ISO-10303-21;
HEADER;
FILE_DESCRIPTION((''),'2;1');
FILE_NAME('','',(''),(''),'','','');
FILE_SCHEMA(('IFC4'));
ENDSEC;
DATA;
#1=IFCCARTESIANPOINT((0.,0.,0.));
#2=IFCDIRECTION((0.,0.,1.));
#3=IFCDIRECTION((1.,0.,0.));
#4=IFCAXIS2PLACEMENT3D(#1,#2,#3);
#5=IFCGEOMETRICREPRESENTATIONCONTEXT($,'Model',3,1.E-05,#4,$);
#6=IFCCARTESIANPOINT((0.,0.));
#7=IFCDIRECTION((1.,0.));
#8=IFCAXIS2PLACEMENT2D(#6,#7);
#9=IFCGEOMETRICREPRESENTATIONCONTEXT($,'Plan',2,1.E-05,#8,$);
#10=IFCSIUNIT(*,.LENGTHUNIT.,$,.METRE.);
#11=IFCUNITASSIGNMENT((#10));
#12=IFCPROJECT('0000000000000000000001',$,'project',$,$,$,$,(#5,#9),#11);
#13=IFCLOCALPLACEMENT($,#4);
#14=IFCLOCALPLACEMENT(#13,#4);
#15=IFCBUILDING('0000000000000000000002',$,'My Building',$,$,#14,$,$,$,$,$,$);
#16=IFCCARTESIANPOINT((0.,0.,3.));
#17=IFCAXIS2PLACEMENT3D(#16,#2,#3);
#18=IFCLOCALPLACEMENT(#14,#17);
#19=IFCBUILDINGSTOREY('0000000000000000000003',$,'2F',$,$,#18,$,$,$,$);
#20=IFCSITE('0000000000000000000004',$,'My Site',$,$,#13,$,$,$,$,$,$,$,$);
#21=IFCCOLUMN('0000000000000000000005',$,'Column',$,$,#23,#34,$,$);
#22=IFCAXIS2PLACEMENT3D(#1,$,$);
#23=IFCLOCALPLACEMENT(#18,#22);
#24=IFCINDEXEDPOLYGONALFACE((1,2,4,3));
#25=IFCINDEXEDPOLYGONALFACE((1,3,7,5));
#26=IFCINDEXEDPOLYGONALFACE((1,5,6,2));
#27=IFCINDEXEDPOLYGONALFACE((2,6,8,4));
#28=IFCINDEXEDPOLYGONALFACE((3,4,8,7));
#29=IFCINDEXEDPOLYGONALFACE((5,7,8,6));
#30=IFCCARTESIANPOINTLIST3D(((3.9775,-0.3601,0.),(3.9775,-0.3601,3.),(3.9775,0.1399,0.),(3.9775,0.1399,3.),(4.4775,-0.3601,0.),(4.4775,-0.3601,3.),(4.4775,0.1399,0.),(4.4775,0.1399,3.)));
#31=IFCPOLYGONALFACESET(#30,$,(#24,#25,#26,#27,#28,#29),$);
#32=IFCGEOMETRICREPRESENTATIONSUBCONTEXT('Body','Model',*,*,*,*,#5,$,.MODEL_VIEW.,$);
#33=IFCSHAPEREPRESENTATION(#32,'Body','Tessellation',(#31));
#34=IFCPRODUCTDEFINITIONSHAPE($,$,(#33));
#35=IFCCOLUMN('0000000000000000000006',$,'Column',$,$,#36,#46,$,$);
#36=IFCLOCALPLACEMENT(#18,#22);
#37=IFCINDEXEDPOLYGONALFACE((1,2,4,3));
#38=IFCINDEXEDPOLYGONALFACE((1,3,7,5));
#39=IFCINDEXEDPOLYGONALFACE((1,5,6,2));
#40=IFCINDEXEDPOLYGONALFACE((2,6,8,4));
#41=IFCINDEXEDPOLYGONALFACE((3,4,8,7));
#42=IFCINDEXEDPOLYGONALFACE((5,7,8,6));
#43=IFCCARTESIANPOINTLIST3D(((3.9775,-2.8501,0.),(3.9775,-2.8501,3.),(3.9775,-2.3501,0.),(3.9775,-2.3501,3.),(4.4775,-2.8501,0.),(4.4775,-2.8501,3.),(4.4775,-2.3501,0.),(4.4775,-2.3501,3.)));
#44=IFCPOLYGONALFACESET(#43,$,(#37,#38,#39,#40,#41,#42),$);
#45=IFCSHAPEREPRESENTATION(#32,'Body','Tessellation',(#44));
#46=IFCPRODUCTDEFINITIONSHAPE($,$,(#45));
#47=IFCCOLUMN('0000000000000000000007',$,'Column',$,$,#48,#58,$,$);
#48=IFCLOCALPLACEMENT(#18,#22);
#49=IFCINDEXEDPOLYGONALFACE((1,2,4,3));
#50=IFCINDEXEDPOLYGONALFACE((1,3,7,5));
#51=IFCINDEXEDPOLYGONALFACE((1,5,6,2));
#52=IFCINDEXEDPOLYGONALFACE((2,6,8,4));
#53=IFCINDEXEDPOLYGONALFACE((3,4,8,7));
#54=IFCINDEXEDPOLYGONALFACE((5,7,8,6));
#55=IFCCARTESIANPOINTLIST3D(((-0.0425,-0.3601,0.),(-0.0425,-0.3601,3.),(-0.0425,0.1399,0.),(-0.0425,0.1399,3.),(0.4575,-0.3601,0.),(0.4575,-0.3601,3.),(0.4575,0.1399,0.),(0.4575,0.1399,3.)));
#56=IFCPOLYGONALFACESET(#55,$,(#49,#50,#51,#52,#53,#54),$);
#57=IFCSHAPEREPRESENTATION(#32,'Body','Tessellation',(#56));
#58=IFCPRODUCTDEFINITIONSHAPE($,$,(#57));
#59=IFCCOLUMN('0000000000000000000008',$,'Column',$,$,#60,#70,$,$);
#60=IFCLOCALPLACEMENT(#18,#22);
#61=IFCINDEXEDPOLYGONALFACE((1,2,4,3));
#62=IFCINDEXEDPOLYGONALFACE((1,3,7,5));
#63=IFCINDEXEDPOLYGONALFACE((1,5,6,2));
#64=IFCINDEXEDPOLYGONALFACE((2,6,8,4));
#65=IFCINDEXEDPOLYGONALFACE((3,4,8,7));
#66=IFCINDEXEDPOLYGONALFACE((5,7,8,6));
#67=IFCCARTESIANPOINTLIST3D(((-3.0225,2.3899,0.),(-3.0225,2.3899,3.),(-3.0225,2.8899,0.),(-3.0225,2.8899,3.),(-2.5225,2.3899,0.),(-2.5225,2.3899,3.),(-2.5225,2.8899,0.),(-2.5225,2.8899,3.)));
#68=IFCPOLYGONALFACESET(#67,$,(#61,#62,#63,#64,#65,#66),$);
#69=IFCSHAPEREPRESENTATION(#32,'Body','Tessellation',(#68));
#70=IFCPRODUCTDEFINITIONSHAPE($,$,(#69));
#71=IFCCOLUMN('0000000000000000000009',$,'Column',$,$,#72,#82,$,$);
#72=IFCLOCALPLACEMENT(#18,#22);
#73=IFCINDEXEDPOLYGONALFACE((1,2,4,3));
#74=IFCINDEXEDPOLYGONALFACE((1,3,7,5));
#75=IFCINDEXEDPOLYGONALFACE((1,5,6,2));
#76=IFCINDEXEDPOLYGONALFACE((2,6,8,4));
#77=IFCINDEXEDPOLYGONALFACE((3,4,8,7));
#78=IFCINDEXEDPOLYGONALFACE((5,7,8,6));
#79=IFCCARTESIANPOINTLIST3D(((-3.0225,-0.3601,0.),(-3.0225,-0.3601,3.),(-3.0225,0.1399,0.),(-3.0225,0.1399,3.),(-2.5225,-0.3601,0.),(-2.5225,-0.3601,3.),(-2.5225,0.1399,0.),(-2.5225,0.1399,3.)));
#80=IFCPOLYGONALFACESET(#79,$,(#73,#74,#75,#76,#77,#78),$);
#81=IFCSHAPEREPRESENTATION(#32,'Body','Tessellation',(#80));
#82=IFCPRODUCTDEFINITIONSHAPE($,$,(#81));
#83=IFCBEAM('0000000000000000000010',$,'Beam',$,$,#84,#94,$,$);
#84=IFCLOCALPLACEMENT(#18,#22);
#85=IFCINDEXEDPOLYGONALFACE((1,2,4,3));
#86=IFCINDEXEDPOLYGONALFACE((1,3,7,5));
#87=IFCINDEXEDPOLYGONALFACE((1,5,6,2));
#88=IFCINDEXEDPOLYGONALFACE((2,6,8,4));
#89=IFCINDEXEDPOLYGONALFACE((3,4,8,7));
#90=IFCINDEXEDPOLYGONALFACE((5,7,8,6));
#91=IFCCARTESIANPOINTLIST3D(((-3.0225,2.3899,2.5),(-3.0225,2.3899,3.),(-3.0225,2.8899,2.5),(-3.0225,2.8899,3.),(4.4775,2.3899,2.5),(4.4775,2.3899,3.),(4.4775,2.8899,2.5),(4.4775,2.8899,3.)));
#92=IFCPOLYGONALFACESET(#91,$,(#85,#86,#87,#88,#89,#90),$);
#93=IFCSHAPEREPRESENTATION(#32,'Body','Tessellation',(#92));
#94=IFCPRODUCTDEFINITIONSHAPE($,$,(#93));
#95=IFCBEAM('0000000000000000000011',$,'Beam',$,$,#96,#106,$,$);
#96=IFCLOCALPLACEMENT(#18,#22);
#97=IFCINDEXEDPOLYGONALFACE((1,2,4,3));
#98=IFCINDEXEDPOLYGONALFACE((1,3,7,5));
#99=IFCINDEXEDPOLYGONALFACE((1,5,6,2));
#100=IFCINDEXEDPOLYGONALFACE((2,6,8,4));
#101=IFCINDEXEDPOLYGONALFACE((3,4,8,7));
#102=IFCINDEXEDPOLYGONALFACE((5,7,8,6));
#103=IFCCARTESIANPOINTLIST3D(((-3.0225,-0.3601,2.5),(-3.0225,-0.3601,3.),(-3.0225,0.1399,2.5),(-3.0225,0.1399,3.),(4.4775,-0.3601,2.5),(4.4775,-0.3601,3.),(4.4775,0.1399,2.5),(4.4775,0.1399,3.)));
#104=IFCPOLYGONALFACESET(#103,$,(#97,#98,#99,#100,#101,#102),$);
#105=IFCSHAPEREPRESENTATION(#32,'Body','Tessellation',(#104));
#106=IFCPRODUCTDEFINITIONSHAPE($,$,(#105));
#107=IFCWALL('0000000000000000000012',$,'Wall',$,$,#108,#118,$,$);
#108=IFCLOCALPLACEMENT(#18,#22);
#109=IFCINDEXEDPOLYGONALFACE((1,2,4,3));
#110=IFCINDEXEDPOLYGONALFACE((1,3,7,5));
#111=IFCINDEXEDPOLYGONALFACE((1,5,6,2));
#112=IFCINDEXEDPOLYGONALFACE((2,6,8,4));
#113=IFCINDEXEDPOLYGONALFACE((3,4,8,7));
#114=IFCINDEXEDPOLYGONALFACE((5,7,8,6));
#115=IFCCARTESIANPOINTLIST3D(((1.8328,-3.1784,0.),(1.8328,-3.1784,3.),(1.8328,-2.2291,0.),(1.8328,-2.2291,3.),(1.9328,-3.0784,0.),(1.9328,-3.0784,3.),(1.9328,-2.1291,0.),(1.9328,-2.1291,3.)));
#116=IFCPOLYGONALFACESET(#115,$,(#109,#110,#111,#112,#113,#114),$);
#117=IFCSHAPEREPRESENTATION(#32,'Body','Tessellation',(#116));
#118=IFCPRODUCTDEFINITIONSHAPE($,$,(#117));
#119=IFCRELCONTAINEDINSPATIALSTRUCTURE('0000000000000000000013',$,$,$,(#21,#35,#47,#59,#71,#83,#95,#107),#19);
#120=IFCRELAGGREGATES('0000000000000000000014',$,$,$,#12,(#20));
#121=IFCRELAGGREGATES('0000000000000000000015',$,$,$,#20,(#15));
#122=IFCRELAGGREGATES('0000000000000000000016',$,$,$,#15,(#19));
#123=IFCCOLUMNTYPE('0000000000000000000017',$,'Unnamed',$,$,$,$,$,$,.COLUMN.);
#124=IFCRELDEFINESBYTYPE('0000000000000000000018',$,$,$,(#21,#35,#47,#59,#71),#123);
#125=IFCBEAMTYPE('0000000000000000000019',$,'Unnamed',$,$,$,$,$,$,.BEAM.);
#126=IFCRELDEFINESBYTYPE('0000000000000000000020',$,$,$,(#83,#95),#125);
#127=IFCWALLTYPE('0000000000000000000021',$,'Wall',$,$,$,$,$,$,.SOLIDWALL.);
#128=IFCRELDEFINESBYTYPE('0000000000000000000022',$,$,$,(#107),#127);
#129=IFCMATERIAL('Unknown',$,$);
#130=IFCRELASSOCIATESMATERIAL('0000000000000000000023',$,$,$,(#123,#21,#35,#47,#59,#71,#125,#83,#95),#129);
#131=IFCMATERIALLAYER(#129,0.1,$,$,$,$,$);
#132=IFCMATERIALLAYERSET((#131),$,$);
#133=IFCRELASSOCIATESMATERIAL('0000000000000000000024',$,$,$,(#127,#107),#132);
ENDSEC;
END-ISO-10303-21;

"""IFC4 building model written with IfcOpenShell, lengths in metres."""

from ifc_helpers import new_model, si_unit, frame, origin_with_axes, origin_2d_with_axis, place, context, subcontext, project, spatial, line, indexed_curve, rectangle, outline, extrude, material, layer, layer_set, layer_usage, material_profile, profile_set, profile_usage, type_object, element, save


model = new_model("IFC4")

# Units and contexts
model_context = context("Model", 3, precision=1e-05, world=origin_with_axes())
plan_context = context("Plan", 2, precision=1e-05, world=origin_2d_with_axis())
body_context_1 = subcontext(model_context, "Body", "Model", "MODEL_VIEW")
ifc_project = project(units=[si_unit("LENGTHUNIT", "METRE")], contexts=[model_context, plan_context])

# Site, building, storey
site_placement = place(None, origin_with_axes())
site = spatial("IfcSite", under=ifc_project, at=site_placement, Name="My Site")
building_placement = place(site_placement, origin_with_axes())
building = spatial("IfcBuilding", under=site, at=building_placement, Name="My Building")
storey_placement = place(building_placement, frame((0.0, 0.0, 3.0), z_axis=(0.0, 0.0, 1.0), x_axis=(1.0, 0.0, 0.0)))
storey = spatial("IfcBuildingStorey", under=building, at=storey_placement, Name="2F")

# Columns
ifc_material = material(Name="Unknown")
ifc_material_profile_1 = material_profile(ifc_material, rectangle(XDim=0.5, YDim=0.5))
ifc_profile_set_1 = profile_set([ifc_material_profile_1])
ifc_profile_usage_1 = profile_usage(ifc_profile_set_1, cardinal=5)
column_type = type_object("IfcColumnType", Name="Unnamed", PredefinedType="COLUMN", material=ifc_profile_set_1)
column_1_placement = place(storey_placement, frame((4.2275, -0.1101, 0.0), z_axis=(0.0, 0.0, 1.0), x_axis=(1.0, 0.0, 0.0)))
element("IfcColumn", 1, at=column_1_placement, inside=storey, type_object=column_type, material=ifc_profile_usage_1, Name="Column", context=body_context_1, shape_type="SweptSolid", body=[
    extrude(rectangle(XDim=0.5, YDim=0.5), origin_with_axes(), (0.0, 0.0, 1.0), 3.0),
])
ifc_profile_usage_2 = profile_usage(ifc_profile_set_1, cardinal=5)
column_2_placement = place(storey_placement, frame((4.2275, -2.6001, 0.0), z_axis=(0.0, 0.0, 1.0), x_axis=(1.0, 0.0, 0.0)))
element("IfcColumn", 2, at=column_2_placement, inside=storey, type_object=column_type, material=ifc_profile_usage_2, Name="Column", context=body_context_1, shape_type="SweptSolid", body=[
    extrude(rectangle(XDim=0.5, YDim=0.5), origin_with_axes(), (0.0, 0.0, 1.0), 3.0),
])
ifc_profile_usage_3 = profile_usage(ifc_profile_set_1, cardinal=5)
column_3_placement = place(storey_placement, frame((0.2075, -0.1101, 0.0), z_axis=(0.0, 0.0, 1.0), x_axis=(1.0, 0.0, 0.0)))
element("IfcColumn", 3, at=column_3_placement, inside=storey, type_object=column_type, material=ifc_profile_usage_3, Name="Column", context=body_context_1, shape_type="SweptSolid", body=[
    extrude(rectangle(XDim=0.5, YDim=0.5), origin_with_axes(), (0.0, 0.0, 1.0), 3.0),
])
ifc_profile_usage_4 = profile_usage(ifc_profile_set_1, cardinal=5)
column_4_placement = place(storey_placement, frame((-2.7725, 2.6399, 0.0), z_axis=(0.0, 0.0, 1.0), x_axis=(1.0, 0.0, 0.0)))
element("IfcColumn", 4, at=column_4_placement, inside=storey, type_object=column_type, material=ifc_profile_usage_4, Name="Column", context=body_context_1, shape_type="SweptSolid", body=[
    extrude(rectangle(XDim=0.5, YDim=0.5), origin_with_axes(), (0.0, 0.0, 1.0), 3.0),
])
ifc_profile_usage_5 = profile_usage(ifc_profile_set_1, cardinal=5)
column_5_placement = place(storey_placement, frame((-2.7725, -0.1101, 0.0), z_axis=(0.0, 0.0, 1.0), x_axis=(1.0, 0.0, 0.0)))
element("IfcColumn", 5, at=column_5_placement, inside=storey, type_object=column_type, material=ifc_profile_usage_5, Name="Column", context=body_context_1, shape_type="SweptSolid", body=[
    extrude(rectangle(XDim=0.5, YDim=0.5), origin_with_axes(), (0.0, 0.0, 1.0), 3.0),
])

# Beams
ifc_material_profile_2 = material_profile(ifc_material, rectangle(XDim=0.5, YDim=0.5))
ifc_profile_set_2 = profile_set([ifc_material_profile_2])
ifc_profile_usage_6 = profile_usage(ifc_profile_set_2, cardinal=7)
beam_type = type_object("IfcBeamType", Name="Unnamed", PredefinedType="BEAM", material=ifc_profile_set_2)
beam_1_placement = place(storey_placement, frame((4.4775, 2.3899, 3.0), z_axis=(-1.0, 0.0, 0.0), x_axis=(0.0, -1.0, 0.0)))
element("IfcBeam", 6, at=beam_1_placement, inside=storey, type_object=beam_type, material=ifc_profile_usage_6, Name="Beam", context=body_context_1, shape_type="SweptSolid", body=[
    extrude(rectangle(XDim=0.5, YDim=0.5), frame((-0.25, -0.25, 0.0), z_axis=(0.0, 0.0, 1.0), x_axis=(1.0, 0.0, 0.0)), (0.0, 0.0, 1.0), 7.5),
])
ifc_profile_usage_7 = profile_usage(ifc_profile_set_2, cardinal=7)
beam_2_placement = place(storey_placement, frame((4.4775, -0.3601, 3.0), z_axis=(-1.0, 0.0, 0.0), x_axis=(0.0, -1.0, 0.0)))
element("IfcBeam", 7, at=beam_2_placement, inside=storey, type_object=beam_type, material=ifc_profile_usage_7, Name="Beam", context=body_context_1, shape_type="SweptSolid", body=[
    extrude(rectangle(XDim=0.5, YDim=0.5), frame((-0.25, -0.25, 0.0), z_axis=(0.0, 0.0, 1.0), x_axis=(1.0, 0.0, 0.0)), (0.0, 0.0, 1.0), 7.5),
])

# Wall
ifc_layer = layer(ifc_material, 0.1)
ifc_layer_set = layer_set([ifc_layer])
ifc_layer_usage_1 = layer_usage(ifc_layer_set, "AXIS2", "POSITIVE", 0.0)
wall_type = type_object("IfcWallType", Name="Wall", PredefinedType="SOLIDWALL", material=ifc_layer_set)
wall_1_placement = place(storey_placement, frame((1.8328, -2.2291, 0.0), z_axis=(0.0, 0.0, 1.0), x_axis=(0.0, -1.0, 0.0)))
element("IfcWall", 8, at=wall_1_placement, inside=storey, type_object=wall_type, material=ifc_layer_usage_1, Name="Wall", context=body_context_1, shape_type="SweptSolid", body=[
    extrude(outline(indexed_curve([(0.0, 0.0), (-0.1, 0.1), (0.8493, 0.1), (0.9493, 0.0)], segments=[line(1, 2, 3, 4, 1)])), origin_with_axes(), (0.0, 0.0, 1.0), 3.0),
])

save(model, "model.ifc")
